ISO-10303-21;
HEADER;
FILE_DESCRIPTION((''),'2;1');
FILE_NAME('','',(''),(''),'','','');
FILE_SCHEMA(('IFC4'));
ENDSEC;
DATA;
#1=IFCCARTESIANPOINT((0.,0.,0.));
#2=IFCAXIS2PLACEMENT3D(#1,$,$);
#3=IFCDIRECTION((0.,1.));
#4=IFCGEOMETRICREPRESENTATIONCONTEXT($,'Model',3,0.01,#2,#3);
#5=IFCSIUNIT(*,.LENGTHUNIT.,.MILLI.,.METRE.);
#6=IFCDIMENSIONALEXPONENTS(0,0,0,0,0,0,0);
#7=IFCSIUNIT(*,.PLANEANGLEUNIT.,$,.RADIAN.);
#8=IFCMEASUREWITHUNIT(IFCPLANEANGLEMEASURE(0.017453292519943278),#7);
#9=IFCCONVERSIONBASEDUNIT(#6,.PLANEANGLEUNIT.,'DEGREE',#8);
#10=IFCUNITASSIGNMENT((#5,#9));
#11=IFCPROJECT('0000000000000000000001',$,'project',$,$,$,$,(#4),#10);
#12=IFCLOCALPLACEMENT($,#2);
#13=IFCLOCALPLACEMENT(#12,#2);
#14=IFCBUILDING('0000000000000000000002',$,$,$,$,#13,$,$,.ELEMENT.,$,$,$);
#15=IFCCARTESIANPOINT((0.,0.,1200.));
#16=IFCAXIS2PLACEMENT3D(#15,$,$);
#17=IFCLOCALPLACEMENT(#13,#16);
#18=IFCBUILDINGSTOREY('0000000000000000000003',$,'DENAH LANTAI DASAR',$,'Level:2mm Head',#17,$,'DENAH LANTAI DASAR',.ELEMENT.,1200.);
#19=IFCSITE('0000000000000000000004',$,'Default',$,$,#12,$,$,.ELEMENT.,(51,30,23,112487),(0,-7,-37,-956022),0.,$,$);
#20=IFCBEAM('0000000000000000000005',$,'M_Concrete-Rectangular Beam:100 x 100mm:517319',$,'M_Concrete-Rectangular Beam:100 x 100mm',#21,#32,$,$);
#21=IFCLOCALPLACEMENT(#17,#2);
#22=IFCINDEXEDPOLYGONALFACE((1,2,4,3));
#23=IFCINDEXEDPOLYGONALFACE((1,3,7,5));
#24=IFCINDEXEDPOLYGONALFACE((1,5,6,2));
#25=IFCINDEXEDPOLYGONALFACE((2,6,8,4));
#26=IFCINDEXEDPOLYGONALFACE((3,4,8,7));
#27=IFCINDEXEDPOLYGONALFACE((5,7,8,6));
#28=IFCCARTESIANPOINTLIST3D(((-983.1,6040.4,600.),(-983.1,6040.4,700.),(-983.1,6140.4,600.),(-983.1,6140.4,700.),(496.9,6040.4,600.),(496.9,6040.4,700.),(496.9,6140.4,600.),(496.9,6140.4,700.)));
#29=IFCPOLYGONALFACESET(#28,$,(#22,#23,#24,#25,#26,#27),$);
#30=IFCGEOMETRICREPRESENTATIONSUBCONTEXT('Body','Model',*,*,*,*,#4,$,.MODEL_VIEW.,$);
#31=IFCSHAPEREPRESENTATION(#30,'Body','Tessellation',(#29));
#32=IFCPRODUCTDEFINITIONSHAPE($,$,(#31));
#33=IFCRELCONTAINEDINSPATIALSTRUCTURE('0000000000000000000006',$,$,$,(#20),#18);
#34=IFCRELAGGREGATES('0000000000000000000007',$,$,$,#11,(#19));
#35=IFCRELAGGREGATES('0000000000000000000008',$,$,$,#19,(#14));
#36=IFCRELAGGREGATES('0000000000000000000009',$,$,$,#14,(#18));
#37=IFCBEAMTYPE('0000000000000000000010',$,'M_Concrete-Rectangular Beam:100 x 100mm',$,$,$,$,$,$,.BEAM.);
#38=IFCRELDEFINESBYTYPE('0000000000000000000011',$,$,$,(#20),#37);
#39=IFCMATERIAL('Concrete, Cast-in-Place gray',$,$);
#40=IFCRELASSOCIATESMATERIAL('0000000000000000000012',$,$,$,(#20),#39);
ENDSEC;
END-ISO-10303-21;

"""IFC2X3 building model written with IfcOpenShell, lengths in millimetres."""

from ifc_helpers import new_model, entity, si_unit, converted_unit, direction, frame, frame_2d, origin, place, context, subcontext, project, spatial, rectangle, extrude, material, type_object, element, save


model = new_model("IFC2X3")

# Units and contexts
model_context = context("Model", 3, precision=0.01, world=origin(), true_north=direction((0.0, 1.0)))
body_context = subcontext(model_context, "Body", "Model", "MODEL_VIEW")
ifc_project = project(units=[si_unit("LENGTHUNIT", "METRE", prefix="MILLI"), converted_unit("PLANEANGLEUNIT", "DEGREE", entity("IfcPlaneAngleMeasure", 0.017453292519943278), si_unit("PLANEANGLEUNIT", "RADIAN"), dimensions=[0, 0, 0, 0, 0, 0, 0])], contexts=[model_context])

# Site, building, storey
site_placement = place(None, origin())
site = spatial("IfcSite", under=ifc_project, at=site_placement, Name="Default", CompositionType="ELEMENT", RefLatitude=(51, 30, 23, 112487), RefLongitude=(0, -7, -37, -956022), RefElevation=0.0)
building_placement = place(site_placement, origin())
building = spatial("IfcBuilding", under=site, at=building_placement, CompositionType="ELEMENT")
storey_placement = place(building_placement, frame((0.0, 0.0, 1200.0)))
storey = spatial("IfcBuildingStorey", under=building, at=storey_placement, Name="DENAH LANTAI DASAR", ObjectType="Level:2mm Head", LongName="DENAH LANTAI DASAR", CompositionType="ELEMENT", Elevation=1200.0)

# Beam
ifc_material_1 = material(Name="Concrete, Cast-in-Place gray")
beam_type = type_object("IfcBeamType", Name="M_Concrete-Rectangular Beam:100 x 100mm", PredefinedType="BEAM")
beam_placement = place(storey_placement, frame((546.9, 6090.4, 700.0), z_axis=(0.0, 0.0, 1.0), x_axis=(-1.0, 0.0, 0.0)))
element("IfcBeam", 1, at=beam_placement, inside=storey, type_object=beam_type, material=ifc_material_1, Name="M_Concrete-Rectangular Beam:100 x 100mm:517319", ObjectType="M_Concrete-Rectangular Beam:100 x 100mm", context=body_context, shape_type="SweptSolid", body=[
    extrude(rectangle(XDim=100.0, YDim=100.0, at=frame_2d((0.0, 0.0), x_axis=(1.0, 0.0))), frame((50.0, 0.0, -50.0), z_axis=(1.0, 0.0, 0.0), x_axis=(0.0, 0.0, -1.0)), (0.0, 0.0, 1.0), 1480.0),
])

save(model, "model.ifc")
